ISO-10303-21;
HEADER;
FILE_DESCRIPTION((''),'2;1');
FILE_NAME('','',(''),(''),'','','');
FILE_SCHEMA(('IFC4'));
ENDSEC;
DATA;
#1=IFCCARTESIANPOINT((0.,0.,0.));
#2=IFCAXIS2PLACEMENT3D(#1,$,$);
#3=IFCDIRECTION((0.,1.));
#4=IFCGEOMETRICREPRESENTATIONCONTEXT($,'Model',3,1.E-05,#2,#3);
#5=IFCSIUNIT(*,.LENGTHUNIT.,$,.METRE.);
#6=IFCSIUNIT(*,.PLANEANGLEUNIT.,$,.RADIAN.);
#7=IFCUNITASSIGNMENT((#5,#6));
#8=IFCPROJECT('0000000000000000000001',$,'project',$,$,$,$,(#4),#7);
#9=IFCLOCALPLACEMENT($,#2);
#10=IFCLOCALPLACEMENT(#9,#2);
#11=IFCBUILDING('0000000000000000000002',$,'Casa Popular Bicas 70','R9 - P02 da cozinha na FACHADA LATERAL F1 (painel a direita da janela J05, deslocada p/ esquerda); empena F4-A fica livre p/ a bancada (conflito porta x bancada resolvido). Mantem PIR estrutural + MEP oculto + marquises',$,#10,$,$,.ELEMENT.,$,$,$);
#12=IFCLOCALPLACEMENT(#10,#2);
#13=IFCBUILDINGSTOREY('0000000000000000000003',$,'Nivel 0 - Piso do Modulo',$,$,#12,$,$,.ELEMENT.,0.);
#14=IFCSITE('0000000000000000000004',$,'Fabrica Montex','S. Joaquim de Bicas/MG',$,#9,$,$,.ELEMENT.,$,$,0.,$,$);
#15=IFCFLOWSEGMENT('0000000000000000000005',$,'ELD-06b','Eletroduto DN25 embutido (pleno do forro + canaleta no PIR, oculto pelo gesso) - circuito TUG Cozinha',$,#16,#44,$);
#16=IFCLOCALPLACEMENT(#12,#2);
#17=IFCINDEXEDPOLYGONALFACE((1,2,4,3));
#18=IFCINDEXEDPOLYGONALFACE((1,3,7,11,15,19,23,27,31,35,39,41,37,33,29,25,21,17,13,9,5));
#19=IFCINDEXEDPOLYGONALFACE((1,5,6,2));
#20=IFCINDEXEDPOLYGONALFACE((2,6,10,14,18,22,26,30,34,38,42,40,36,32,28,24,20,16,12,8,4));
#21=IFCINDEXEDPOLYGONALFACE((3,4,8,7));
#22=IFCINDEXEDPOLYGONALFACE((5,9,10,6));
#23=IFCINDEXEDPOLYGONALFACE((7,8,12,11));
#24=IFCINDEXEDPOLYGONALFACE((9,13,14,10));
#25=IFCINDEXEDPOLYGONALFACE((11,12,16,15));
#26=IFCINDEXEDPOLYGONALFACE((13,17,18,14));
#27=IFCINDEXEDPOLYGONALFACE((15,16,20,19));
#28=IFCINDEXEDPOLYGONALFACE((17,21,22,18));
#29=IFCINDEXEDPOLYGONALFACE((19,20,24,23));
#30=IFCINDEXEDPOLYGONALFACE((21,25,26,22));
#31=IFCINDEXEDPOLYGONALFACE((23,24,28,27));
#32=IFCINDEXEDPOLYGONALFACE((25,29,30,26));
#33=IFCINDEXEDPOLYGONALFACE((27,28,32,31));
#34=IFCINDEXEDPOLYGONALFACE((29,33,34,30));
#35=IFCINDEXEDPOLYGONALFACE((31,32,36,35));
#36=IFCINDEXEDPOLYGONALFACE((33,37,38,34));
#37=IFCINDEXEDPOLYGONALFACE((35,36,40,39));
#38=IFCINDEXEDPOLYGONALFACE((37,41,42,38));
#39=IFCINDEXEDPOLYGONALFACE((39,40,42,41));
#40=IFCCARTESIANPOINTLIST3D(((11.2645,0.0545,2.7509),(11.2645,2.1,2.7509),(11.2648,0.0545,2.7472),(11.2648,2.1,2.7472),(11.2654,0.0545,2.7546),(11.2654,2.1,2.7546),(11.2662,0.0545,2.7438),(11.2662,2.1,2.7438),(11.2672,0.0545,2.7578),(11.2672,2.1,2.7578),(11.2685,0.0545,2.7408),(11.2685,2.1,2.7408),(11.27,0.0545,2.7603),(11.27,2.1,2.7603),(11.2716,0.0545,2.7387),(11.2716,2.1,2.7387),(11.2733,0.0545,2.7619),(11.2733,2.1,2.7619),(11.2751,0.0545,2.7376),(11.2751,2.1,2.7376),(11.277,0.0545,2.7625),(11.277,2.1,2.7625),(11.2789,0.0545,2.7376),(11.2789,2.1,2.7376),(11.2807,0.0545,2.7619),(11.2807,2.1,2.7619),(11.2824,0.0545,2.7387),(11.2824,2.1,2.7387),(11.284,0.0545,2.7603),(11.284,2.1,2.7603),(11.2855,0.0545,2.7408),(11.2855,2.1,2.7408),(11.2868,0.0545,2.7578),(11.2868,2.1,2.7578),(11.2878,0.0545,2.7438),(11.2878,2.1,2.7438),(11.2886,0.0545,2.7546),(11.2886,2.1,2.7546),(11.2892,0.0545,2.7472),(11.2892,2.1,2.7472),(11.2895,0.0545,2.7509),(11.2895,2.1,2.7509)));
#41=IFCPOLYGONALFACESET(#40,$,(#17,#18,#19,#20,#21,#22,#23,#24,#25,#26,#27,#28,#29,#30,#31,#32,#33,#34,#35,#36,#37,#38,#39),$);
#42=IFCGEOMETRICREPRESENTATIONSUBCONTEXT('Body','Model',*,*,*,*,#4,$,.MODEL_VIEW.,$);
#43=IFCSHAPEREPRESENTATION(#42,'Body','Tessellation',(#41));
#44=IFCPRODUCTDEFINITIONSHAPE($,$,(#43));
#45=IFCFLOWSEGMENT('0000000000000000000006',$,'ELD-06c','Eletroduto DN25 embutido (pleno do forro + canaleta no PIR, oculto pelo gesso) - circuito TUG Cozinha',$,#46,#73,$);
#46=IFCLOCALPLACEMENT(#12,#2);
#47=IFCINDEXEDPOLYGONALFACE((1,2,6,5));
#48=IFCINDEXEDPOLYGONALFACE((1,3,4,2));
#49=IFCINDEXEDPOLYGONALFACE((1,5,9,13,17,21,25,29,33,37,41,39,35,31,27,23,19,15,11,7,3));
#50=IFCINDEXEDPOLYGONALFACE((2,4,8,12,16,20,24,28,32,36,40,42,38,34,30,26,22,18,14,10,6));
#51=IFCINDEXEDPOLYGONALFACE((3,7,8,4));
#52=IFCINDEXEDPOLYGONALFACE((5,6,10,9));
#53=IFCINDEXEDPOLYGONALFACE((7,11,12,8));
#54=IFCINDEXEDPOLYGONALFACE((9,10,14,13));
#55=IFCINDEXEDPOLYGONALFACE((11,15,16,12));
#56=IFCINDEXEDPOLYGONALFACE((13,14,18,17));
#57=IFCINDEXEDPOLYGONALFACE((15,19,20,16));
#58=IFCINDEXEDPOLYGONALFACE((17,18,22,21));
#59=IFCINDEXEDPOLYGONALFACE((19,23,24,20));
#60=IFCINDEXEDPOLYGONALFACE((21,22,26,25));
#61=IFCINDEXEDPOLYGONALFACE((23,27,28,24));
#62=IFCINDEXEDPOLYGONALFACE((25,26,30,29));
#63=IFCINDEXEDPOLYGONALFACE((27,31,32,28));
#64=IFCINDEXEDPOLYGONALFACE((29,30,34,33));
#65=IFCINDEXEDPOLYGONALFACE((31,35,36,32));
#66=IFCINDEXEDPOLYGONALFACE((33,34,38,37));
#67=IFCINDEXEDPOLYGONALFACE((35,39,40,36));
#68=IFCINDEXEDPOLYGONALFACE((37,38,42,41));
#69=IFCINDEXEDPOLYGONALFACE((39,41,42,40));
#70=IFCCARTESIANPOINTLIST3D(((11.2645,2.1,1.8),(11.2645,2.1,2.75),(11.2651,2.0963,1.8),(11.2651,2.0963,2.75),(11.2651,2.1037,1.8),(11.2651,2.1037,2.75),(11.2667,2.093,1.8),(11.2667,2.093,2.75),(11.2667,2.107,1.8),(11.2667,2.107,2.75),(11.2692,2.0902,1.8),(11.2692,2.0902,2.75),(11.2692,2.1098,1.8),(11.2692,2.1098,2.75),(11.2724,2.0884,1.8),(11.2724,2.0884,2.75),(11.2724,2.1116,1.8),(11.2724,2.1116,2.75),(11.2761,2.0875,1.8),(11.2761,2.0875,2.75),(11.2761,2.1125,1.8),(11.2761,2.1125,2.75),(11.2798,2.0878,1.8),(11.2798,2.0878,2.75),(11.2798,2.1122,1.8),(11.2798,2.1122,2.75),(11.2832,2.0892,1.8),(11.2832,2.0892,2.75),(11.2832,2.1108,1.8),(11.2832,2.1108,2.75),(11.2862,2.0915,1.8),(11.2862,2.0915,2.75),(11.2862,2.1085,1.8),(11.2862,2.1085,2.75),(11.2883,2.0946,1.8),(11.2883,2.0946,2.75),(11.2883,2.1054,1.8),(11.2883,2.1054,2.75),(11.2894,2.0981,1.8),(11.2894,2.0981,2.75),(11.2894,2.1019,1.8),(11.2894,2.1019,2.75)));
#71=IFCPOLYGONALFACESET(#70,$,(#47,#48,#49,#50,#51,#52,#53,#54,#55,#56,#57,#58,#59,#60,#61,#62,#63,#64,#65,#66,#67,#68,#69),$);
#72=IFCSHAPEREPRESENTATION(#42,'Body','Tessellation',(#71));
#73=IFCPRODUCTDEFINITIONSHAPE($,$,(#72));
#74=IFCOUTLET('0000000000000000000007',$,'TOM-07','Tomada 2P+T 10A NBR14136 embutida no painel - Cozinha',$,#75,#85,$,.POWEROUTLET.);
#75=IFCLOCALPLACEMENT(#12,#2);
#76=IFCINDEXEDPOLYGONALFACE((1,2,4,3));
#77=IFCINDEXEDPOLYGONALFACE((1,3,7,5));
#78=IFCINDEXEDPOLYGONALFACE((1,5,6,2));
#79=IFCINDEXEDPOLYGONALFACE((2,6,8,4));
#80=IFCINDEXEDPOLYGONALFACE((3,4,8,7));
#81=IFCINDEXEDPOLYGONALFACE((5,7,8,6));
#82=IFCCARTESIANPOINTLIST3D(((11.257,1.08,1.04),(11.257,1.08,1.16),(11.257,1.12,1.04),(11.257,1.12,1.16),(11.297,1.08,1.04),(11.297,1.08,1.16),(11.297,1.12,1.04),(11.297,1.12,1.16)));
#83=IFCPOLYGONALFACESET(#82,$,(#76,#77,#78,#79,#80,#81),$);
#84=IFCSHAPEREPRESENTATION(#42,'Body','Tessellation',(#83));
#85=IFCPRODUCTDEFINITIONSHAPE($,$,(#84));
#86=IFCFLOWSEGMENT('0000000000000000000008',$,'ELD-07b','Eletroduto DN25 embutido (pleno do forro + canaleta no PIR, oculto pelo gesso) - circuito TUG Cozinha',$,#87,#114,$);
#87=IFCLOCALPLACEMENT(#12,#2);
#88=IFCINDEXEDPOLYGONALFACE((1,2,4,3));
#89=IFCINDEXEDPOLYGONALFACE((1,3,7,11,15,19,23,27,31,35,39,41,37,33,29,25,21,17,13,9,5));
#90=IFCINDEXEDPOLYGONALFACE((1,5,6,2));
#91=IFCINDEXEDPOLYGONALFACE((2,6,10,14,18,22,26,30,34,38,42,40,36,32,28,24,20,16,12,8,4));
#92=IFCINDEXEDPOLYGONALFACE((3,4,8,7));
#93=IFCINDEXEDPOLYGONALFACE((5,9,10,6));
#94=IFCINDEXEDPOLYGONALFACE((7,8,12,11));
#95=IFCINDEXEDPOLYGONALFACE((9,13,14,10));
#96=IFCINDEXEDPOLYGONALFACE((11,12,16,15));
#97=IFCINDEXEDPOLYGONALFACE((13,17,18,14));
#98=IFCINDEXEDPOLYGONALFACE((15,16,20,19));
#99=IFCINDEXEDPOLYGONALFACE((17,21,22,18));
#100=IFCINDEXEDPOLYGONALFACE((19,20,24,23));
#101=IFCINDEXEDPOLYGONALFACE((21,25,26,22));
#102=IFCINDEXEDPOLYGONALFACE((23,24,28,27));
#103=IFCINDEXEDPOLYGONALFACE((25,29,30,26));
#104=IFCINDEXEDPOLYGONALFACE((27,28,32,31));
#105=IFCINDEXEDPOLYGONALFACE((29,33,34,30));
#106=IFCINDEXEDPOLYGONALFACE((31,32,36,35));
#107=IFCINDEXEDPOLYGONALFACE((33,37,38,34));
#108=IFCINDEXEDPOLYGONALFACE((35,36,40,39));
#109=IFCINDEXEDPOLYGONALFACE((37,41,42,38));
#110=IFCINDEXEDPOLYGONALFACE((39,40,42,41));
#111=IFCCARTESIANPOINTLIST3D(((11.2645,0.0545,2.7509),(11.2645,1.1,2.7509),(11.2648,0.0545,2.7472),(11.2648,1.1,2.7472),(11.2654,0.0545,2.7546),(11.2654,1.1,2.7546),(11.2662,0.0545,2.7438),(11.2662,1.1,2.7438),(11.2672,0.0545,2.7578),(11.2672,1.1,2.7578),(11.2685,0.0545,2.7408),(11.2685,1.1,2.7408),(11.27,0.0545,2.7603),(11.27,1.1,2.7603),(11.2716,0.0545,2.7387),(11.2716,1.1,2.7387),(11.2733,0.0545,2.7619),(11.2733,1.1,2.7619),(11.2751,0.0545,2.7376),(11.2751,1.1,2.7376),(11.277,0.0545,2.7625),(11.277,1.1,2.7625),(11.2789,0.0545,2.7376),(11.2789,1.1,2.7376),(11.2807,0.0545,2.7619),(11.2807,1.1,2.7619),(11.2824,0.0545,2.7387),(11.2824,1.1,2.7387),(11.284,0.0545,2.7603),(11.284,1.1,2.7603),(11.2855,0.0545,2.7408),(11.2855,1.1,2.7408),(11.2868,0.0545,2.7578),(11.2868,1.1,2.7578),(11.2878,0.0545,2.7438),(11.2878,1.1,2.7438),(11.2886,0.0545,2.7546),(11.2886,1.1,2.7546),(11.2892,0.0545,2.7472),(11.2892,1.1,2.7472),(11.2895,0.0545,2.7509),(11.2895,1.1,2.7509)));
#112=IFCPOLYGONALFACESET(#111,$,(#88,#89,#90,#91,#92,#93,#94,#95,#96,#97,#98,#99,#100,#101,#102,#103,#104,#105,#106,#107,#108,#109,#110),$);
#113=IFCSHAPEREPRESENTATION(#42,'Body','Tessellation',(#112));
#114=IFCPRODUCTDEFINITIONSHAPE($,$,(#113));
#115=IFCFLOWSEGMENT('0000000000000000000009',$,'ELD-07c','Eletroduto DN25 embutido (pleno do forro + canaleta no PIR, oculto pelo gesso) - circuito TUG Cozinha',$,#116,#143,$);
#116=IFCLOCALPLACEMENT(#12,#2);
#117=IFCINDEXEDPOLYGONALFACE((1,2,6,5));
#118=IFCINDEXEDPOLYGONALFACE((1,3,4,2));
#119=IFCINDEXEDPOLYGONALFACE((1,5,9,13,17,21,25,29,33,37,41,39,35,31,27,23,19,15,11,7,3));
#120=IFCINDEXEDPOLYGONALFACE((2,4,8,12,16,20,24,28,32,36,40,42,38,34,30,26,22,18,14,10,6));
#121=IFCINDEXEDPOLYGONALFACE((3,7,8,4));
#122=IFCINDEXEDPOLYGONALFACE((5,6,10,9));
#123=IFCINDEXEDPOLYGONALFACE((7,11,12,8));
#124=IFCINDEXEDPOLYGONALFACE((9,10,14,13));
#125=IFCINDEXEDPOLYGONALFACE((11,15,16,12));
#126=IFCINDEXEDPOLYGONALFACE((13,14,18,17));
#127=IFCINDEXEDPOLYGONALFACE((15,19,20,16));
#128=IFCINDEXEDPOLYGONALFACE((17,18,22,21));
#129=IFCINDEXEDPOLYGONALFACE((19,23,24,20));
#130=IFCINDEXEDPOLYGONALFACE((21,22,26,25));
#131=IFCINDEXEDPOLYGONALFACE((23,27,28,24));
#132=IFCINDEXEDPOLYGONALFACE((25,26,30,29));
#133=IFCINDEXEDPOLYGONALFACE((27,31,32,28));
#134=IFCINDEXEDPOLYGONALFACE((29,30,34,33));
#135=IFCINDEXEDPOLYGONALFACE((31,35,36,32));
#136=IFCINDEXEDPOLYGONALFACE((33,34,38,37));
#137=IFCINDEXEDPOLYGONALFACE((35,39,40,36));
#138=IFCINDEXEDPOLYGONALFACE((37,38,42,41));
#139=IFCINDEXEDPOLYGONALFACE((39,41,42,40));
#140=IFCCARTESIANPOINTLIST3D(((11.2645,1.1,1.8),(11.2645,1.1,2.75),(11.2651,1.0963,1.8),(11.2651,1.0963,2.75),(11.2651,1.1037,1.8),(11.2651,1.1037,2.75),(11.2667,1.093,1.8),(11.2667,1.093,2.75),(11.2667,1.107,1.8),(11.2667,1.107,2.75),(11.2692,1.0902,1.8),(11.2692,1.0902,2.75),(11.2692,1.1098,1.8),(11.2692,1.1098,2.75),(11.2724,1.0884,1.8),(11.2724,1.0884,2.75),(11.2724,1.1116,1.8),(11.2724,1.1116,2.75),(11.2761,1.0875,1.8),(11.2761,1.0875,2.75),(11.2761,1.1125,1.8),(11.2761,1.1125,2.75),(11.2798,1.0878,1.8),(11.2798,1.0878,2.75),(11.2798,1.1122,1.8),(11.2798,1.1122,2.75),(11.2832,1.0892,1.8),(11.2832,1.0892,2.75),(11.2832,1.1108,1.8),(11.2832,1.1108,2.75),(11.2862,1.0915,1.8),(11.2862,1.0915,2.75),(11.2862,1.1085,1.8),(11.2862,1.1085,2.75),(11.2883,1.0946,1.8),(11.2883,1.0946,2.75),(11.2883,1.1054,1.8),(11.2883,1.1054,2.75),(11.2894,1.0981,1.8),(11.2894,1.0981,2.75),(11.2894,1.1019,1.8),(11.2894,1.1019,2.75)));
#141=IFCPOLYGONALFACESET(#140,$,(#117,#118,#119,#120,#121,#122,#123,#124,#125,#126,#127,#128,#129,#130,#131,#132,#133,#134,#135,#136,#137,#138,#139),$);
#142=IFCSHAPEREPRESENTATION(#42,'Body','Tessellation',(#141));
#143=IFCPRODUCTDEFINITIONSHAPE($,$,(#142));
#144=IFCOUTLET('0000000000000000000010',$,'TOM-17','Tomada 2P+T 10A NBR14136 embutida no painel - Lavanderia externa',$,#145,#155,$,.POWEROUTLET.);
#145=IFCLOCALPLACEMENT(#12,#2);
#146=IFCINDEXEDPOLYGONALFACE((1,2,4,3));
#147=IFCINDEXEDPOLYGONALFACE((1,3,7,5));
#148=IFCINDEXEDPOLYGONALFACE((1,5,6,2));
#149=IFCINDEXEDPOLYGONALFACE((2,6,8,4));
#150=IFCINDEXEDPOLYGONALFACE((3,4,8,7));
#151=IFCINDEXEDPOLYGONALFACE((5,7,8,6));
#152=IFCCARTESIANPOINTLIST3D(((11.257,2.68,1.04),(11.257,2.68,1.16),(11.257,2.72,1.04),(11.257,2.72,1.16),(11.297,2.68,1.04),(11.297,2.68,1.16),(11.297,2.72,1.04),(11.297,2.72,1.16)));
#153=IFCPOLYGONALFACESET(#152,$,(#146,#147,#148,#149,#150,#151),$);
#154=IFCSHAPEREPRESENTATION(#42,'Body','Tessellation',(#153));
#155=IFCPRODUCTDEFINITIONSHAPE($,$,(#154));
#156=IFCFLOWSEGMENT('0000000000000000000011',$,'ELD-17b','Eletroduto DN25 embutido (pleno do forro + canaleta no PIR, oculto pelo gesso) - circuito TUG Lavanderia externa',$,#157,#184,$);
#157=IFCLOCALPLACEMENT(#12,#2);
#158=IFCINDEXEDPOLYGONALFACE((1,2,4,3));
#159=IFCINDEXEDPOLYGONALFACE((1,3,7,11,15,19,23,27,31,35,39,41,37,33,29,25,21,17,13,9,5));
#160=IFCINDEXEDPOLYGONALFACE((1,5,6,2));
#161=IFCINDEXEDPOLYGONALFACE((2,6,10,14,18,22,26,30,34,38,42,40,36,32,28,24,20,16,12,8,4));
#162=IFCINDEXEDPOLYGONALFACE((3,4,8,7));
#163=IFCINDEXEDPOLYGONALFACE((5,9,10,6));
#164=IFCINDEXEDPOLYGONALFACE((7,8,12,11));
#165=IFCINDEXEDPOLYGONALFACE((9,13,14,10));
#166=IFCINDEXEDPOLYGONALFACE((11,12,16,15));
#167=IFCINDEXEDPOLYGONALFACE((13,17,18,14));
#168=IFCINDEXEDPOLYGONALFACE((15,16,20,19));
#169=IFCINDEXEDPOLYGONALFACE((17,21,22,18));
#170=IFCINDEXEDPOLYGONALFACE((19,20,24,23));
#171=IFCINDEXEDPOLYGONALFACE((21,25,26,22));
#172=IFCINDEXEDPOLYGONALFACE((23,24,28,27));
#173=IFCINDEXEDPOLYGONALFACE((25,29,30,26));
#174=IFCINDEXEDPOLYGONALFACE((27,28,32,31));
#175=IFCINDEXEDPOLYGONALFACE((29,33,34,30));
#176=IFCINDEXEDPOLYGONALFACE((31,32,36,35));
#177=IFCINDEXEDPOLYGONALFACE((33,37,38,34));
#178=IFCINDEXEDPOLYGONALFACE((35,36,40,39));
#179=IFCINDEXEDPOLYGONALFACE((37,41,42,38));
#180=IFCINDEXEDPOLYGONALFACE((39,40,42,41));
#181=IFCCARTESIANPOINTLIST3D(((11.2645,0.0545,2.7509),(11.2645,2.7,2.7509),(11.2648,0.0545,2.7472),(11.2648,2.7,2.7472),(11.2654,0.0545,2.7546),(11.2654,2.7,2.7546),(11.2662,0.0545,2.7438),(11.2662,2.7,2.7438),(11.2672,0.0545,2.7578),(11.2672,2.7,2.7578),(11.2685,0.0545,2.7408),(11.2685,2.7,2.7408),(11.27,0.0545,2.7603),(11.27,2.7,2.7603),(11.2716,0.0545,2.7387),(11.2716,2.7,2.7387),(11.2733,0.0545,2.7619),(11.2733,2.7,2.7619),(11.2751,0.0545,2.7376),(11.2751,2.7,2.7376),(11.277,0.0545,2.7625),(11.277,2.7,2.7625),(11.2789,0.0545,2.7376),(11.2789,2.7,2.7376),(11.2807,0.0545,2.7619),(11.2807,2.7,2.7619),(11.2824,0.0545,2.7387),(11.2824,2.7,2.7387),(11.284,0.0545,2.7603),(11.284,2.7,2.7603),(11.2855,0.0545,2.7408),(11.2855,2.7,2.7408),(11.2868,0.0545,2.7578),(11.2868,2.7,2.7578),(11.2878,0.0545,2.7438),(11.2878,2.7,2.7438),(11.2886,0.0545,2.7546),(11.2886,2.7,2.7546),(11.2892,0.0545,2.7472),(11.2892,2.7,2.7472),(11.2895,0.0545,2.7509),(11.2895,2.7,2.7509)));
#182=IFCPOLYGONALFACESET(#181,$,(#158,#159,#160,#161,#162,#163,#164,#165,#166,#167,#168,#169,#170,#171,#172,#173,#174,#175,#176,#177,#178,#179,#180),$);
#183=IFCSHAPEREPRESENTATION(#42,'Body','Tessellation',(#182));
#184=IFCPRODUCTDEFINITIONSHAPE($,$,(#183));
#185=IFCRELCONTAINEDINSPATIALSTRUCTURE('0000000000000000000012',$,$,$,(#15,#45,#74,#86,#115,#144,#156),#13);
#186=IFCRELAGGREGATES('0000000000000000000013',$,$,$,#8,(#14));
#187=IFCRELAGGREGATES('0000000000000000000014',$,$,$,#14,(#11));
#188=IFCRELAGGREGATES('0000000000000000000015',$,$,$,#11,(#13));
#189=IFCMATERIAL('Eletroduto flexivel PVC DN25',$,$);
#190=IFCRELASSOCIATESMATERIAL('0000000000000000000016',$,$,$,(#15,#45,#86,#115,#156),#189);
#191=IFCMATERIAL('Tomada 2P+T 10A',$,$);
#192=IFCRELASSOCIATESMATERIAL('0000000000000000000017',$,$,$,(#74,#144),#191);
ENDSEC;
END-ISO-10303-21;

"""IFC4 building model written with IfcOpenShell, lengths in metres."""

from ifc_helpers import new_model, si_unit, direction, frame, frame_2d, origin, origin_2d, place, context, subcontext, project, spatial, rectangle, circle, extrude, material, element, save


model = new_model("IFC4")

# Units and contexts
model_context = context("Model", 3, precision=1e-05, world=origin(), true_north=direction((0.0, 1.0)))
body_context = subcontext(model_context, "Body", "Model", "MODEL_VIEW")
ifc_project = project(units=[si_unit("LENGTHUNIT", "METRE"), si_unit("PLANEANGLEUNIT", "RADIAN")], contexts=[model_context])

# Site, building, storey
site_placement = place(None, origin())
site = spatial("IfcSite", under=ifc_project, at=site_placement, Name="Fabrica Montex", Description="S. Joaquim de Bicas/MG", CompositionType="ELEMENT", RefElevation=0.0)
building_placement = place(site_placement, origin())
building = spatial("IfcBuilding", under=site, at=building_placement, Name="Casa Popular Bicas 70", Description="R9 - P02 da cozinha na FACHADA LATERAL F1 (painel a direita da janela J05, deslocada p/ esquerda); empena F4-A fica livre p/ a bancada (conflito porta x bancada resolvido). Mantem PIR estrutural + MEP oculto + marquises", CompositionType="ELEMENT")
storey_placement = place(building_placement, origin())
storey = spatial("IfcBuildingStorey", under=building, at=storey_placement, Name="Nivel 0 - Piso do Modulo", CompositionType="ELEMENT", Elevation=0.0)

# Shared definitions
ifc_material_1 = material(Name="Eletroduto flexivel PVC DN25")

# Shared definitions
ifc_material_2 = material(Name="Tomada 2P+T 10A")

# Flow segments
flow_segment_1_placement = place(None, frame((11.277, 0.0545, 2.75), z_axis=(0.0, 1.0, 0.0), x_axis=(0.0, 0.0, 1.0)))
element("IfcFlowSegment", 1, at=flow_segment_1_placement, inside=storey, material=ifc_material_1, Name="ELD-06b", Description="Eletroduto DN25 embutido (pleno do forro + canaleta no PIR, oculto pelo gesso) - circuito TUG Cozinha", context=body_context, shape_type="SweptSolid", body=[
    extrude(circle(Radius=0.0125, at=origin_2d()), origin(), (0.0, 0.0, 1.0), 2.0455),
])
flow_segment_2_placement = place(None, frame((11.277, 2.1, 2.75), z_axis=(0.0, 0.0, -1.0), x_axis=(-1.0, 0.0, 0.0)))
element("IfcFlowSegment", 2, at=flow_segment_2_placement, inside=storey, material=ifc_material_1, Name="ELD-06c", Description="Eletroduto DN25 embutido (pleno do forro + canaleta no PIR, oculto pelo gesso) - circuito TUG Cozinha", context=body_context, shape_type="SweptSolid", body=[
    extrude(circle(Radius=0.0125, at=origin_2d()), origin(), (0.0, 0.0, 1.0), 0.95),
])

# Outlet
outlet_1_placement = place(None, frame((11.297, 1.12, 1.04), z_axis=(0.0, 0.0, 1.0), x_axis=(-1.0, 0.0, 0.0)))
element("IfcOutlet", 3, at=outlet_1_placement, inside=storey, material=ifc_material_2, Name="TOM-07", Description="Tomada 2P+T 10A NBR14136 embutida no painel - Cozinha", PredefinedType="POWEROUTLET", context=body_context, shape_type="SweptSolid", body=[
    extrude(rectangle(XDim=0.04, YDim=0.04, at=frame_2d((0.02, 0.02))), origin(), (0.0, 0.0, 1.0), 0.12),
])

# Flow segments
flow_segment_3_placement = place(None, frame((11.277, 0.0545, 2.75), z_axis=(0.0, 1.0, 0.0), x_axis=(0.0, 0.0, 1.0)))
element("IfcFlowSegment", 4, at=flow_segment_3_placement, inside=storey, material=ifc_material_1, Name="ELD-07b", Description="Eletroduto DN25 embutido (pleno do forro + canaleta no PIR, oculto pelo gesso) - circuito TUG Cozinha", context=body_context, shape_type="SweptSolid", body=[
    extrude(circle(Radius=0.0125, at=origin_2d()), origin(), (0.0, 0.0, 1.0), 1.0455),
])
flow_segment_4_placement = place(None, frame((11.277, 1.1, 2.75), z_axis=(0.0, 0.0, -1.0), x_axis=(-1.0, 0.0, 0.0)))
element("IfcFlowSegment", 5, at=flow_segment_4_placement, inside=storey, material=ifc_material_1, Name="ELD-07c", Description="Eletroduto DN25 embutido (pleno do forro + canaleta no PIR, oculto pelo gesso) - circuito TUG Cozinha", context=body_context, shape_type="SweptSolid", body=[
    extrude(circle(Radius=0.0125, at=origin_2d()), origin(), (0.0, 0.0, 1.0), 0.95),
])

# Outlet
outlet_2_placement = place(None, frame((11.297, 2.72, 1.04), z_axis=(0.0, 0.0, 1.0), x_axis=(-1.0, 0.0, 0.0)))
element("IfcOutlet", 6, at=outlet_2_placement, inside=storey, material=ifc_material_2, Name="TOM-17", Description="Tomada 2P+T 10A NBR14136 embutida no painel - Lavanderia externa", PredefinedType="POWEROUTLET", context=body_context, shape_type="SweptSolid", body=[
    extrude(rectangle(XDim=0.04, YDim=0.04, at=frame_2d((0.02, 0.02))), origin(), (0.0, 0.0, 1.0), 0.12),
])

# Flow segment
flow_segment_5_placement = place(None, frame((11.277, 0.0545, 2.75), z_axis=(0.0, 1.0, 0.0), x_axis=(0.0, 0.0, 1.0)))
element("IfcFlowSegment", 7, at=flow_segment_5_placement, inside=storey, material=ifc_material_1, Name="ELD-17b", Description="Eletroduto DN25 embutido (pleno do forro + canaleta no PIR, oculto pelo gesso) - circuito TUG Lavanderia externa", context=body_context, shape_type="SweptSolid", body=[
    extrude(circle(Radius=0.0125, at=origin_2d()), origin(), (0.0, 0.0, 1.0), 2.6455),
])

save(model, "model.ifc")
